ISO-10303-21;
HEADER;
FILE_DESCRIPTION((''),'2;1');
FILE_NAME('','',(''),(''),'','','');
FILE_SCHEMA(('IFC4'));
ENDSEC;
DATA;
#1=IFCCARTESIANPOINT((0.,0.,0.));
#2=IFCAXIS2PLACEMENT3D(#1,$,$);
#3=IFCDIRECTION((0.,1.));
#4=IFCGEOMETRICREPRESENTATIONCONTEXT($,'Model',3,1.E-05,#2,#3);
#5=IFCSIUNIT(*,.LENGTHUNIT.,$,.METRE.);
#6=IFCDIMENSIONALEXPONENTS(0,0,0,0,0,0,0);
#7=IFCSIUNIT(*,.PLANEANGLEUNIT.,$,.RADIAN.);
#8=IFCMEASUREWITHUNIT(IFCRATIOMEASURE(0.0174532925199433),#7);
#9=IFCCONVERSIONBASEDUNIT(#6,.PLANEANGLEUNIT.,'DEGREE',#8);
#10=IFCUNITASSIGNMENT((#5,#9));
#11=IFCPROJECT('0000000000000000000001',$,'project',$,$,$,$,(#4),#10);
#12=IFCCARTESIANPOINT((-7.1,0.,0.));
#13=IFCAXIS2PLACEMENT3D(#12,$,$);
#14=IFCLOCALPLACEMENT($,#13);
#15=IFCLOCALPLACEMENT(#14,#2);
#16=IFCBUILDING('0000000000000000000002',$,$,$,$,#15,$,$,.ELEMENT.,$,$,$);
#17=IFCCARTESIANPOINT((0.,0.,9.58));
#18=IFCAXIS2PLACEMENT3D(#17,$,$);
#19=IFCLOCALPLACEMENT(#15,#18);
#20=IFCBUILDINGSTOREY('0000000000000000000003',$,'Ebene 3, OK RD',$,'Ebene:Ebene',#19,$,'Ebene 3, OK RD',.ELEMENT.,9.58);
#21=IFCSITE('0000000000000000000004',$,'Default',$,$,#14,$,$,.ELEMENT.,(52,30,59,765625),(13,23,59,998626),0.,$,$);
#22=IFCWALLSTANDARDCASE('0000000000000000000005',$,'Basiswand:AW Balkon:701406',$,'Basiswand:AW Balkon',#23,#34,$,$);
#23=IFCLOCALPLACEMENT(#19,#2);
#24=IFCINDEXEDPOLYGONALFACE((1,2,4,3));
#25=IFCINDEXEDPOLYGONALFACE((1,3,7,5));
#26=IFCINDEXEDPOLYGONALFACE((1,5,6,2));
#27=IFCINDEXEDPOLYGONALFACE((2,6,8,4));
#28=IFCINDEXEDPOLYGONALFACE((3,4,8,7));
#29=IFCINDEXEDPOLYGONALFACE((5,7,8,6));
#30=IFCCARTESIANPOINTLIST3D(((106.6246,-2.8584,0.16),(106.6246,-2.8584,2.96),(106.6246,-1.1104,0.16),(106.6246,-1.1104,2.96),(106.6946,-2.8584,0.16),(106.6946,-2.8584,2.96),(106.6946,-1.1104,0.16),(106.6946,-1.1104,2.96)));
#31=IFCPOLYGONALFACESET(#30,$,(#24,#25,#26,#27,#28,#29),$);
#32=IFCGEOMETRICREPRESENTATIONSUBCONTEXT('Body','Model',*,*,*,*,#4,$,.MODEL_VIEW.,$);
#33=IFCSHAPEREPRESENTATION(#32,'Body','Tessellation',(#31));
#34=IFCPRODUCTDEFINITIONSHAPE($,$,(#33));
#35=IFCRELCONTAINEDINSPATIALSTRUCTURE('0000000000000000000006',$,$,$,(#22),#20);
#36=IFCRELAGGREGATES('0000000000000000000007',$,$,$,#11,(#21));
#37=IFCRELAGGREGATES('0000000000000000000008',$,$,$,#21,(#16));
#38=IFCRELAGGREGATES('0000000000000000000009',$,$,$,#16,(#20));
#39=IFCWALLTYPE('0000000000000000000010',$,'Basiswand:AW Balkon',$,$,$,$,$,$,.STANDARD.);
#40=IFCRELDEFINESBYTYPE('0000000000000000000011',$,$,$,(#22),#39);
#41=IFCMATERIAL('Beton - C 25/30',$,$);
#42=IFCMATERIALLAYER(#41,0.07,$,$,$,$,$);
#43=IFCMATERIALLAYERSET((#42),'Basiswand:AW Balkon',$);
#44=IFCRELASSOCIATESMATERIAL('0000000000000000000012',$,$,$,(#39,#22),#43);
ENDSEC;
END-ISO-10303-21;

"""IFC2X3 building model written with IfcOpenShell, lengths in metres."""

from ifc_helpers import new_model, entity, si_unit, converted_unit, direction, frame, frame_2d, origin, place, context, subcontext, project, spatial, rectangle, extrude, material, layer, layer_set, layer_usage, type_object, element, save


model = new_model("IFC2X3")

# Units and contexts
model_context = context("Model", 3, precision=1e-05, world=origin(), true_north=direction((0.0, 1.0)))
body_context = subcontext(model_context, "Body", "Model", "MODEL_VIEW")
ifc_project = project(units=[si_unit("LENGTHUNIT", "METRE"), converted_unit("PLANEANGLEUNIT", "DEGREE", entity("IfcRatioMeasure", 0.0174532925199433), si_unit("PLANEANGLEUNIT", "RADIAN"), dimensions=[0, 0, 0, 0, 0, 0, 0])], contexts=[model_context])

# Site, building, storey
site_placement = place(None, frame((-7.1, 0.0, 0.0)))
site = spatial("IfcSite", under=ifc_project, at=site_placement, Name="Default", CompositionType="ELEMENT", RefLatitude=(52, 30, 59, 765625), RefLongitude=(13, 23, 59, 998626), RefElevation=0.0)
building_placement = place(site_placement, origin())
building = spatial("IfcBuilding", under=site, at=building_placement, CompositionType="ELEMENT")
storey_placement = place(building_placement, frame((0.0, 0.0, 9.58)))
storey = spatial("IfcBuildingStorey", under=building, at=storey_placement, Name="Ebene 3, OK RD", ObjectType="Ebene:Ebene", LongName="Ebene 3, OK RD", CompositionType="ELEMENT", Elevation=9.58)

# Wall
ifc_material_1 = material(Name="Beton - C 25/30")
ifc_layer_1 = layer(ifc_material_1, 0.07)
ifc_layer_set_1 = layer_set([ifc_layer_1], Name="Basiswand:AW Balkon")
ifc_layer_usage_1 = layer_usage(ifc_layer_set_1, "AXIS2", "NEGATIVE", 0.035)
wall_type_1 = type_object("IfcWallType", Name="Basiswand:AW Balkon", PredefinedType="STANDARD", material=ifc_layer_set_1)
wall_1_placement = place(storey_placement, frame((106.6596, -1.1104, 0.16), z_axis=(0.0, 0.0, 1.0), x_axis=(0.0, -1.0, 0.0)))
element("IfcWallStandardCase", 1, at=wall_1_placement, inside=storey, type_object=wall_type_1, material=ifc_layer_usage_1, Name="Basiswand:AW Balkon:701406", ObjectType="Basiswand:AW Balkon", context=body_context, shape_type="SweptSolid", body=[
    extrude(rectangle(XDim=1.748, YDim=0.07, at=frame_2d((0.874, 0.0), x_axis=(-1.0, 0.0))), origin(), (0.0, 0.0, 1.0), 2.8),
])

save(model, "model.ifc")
